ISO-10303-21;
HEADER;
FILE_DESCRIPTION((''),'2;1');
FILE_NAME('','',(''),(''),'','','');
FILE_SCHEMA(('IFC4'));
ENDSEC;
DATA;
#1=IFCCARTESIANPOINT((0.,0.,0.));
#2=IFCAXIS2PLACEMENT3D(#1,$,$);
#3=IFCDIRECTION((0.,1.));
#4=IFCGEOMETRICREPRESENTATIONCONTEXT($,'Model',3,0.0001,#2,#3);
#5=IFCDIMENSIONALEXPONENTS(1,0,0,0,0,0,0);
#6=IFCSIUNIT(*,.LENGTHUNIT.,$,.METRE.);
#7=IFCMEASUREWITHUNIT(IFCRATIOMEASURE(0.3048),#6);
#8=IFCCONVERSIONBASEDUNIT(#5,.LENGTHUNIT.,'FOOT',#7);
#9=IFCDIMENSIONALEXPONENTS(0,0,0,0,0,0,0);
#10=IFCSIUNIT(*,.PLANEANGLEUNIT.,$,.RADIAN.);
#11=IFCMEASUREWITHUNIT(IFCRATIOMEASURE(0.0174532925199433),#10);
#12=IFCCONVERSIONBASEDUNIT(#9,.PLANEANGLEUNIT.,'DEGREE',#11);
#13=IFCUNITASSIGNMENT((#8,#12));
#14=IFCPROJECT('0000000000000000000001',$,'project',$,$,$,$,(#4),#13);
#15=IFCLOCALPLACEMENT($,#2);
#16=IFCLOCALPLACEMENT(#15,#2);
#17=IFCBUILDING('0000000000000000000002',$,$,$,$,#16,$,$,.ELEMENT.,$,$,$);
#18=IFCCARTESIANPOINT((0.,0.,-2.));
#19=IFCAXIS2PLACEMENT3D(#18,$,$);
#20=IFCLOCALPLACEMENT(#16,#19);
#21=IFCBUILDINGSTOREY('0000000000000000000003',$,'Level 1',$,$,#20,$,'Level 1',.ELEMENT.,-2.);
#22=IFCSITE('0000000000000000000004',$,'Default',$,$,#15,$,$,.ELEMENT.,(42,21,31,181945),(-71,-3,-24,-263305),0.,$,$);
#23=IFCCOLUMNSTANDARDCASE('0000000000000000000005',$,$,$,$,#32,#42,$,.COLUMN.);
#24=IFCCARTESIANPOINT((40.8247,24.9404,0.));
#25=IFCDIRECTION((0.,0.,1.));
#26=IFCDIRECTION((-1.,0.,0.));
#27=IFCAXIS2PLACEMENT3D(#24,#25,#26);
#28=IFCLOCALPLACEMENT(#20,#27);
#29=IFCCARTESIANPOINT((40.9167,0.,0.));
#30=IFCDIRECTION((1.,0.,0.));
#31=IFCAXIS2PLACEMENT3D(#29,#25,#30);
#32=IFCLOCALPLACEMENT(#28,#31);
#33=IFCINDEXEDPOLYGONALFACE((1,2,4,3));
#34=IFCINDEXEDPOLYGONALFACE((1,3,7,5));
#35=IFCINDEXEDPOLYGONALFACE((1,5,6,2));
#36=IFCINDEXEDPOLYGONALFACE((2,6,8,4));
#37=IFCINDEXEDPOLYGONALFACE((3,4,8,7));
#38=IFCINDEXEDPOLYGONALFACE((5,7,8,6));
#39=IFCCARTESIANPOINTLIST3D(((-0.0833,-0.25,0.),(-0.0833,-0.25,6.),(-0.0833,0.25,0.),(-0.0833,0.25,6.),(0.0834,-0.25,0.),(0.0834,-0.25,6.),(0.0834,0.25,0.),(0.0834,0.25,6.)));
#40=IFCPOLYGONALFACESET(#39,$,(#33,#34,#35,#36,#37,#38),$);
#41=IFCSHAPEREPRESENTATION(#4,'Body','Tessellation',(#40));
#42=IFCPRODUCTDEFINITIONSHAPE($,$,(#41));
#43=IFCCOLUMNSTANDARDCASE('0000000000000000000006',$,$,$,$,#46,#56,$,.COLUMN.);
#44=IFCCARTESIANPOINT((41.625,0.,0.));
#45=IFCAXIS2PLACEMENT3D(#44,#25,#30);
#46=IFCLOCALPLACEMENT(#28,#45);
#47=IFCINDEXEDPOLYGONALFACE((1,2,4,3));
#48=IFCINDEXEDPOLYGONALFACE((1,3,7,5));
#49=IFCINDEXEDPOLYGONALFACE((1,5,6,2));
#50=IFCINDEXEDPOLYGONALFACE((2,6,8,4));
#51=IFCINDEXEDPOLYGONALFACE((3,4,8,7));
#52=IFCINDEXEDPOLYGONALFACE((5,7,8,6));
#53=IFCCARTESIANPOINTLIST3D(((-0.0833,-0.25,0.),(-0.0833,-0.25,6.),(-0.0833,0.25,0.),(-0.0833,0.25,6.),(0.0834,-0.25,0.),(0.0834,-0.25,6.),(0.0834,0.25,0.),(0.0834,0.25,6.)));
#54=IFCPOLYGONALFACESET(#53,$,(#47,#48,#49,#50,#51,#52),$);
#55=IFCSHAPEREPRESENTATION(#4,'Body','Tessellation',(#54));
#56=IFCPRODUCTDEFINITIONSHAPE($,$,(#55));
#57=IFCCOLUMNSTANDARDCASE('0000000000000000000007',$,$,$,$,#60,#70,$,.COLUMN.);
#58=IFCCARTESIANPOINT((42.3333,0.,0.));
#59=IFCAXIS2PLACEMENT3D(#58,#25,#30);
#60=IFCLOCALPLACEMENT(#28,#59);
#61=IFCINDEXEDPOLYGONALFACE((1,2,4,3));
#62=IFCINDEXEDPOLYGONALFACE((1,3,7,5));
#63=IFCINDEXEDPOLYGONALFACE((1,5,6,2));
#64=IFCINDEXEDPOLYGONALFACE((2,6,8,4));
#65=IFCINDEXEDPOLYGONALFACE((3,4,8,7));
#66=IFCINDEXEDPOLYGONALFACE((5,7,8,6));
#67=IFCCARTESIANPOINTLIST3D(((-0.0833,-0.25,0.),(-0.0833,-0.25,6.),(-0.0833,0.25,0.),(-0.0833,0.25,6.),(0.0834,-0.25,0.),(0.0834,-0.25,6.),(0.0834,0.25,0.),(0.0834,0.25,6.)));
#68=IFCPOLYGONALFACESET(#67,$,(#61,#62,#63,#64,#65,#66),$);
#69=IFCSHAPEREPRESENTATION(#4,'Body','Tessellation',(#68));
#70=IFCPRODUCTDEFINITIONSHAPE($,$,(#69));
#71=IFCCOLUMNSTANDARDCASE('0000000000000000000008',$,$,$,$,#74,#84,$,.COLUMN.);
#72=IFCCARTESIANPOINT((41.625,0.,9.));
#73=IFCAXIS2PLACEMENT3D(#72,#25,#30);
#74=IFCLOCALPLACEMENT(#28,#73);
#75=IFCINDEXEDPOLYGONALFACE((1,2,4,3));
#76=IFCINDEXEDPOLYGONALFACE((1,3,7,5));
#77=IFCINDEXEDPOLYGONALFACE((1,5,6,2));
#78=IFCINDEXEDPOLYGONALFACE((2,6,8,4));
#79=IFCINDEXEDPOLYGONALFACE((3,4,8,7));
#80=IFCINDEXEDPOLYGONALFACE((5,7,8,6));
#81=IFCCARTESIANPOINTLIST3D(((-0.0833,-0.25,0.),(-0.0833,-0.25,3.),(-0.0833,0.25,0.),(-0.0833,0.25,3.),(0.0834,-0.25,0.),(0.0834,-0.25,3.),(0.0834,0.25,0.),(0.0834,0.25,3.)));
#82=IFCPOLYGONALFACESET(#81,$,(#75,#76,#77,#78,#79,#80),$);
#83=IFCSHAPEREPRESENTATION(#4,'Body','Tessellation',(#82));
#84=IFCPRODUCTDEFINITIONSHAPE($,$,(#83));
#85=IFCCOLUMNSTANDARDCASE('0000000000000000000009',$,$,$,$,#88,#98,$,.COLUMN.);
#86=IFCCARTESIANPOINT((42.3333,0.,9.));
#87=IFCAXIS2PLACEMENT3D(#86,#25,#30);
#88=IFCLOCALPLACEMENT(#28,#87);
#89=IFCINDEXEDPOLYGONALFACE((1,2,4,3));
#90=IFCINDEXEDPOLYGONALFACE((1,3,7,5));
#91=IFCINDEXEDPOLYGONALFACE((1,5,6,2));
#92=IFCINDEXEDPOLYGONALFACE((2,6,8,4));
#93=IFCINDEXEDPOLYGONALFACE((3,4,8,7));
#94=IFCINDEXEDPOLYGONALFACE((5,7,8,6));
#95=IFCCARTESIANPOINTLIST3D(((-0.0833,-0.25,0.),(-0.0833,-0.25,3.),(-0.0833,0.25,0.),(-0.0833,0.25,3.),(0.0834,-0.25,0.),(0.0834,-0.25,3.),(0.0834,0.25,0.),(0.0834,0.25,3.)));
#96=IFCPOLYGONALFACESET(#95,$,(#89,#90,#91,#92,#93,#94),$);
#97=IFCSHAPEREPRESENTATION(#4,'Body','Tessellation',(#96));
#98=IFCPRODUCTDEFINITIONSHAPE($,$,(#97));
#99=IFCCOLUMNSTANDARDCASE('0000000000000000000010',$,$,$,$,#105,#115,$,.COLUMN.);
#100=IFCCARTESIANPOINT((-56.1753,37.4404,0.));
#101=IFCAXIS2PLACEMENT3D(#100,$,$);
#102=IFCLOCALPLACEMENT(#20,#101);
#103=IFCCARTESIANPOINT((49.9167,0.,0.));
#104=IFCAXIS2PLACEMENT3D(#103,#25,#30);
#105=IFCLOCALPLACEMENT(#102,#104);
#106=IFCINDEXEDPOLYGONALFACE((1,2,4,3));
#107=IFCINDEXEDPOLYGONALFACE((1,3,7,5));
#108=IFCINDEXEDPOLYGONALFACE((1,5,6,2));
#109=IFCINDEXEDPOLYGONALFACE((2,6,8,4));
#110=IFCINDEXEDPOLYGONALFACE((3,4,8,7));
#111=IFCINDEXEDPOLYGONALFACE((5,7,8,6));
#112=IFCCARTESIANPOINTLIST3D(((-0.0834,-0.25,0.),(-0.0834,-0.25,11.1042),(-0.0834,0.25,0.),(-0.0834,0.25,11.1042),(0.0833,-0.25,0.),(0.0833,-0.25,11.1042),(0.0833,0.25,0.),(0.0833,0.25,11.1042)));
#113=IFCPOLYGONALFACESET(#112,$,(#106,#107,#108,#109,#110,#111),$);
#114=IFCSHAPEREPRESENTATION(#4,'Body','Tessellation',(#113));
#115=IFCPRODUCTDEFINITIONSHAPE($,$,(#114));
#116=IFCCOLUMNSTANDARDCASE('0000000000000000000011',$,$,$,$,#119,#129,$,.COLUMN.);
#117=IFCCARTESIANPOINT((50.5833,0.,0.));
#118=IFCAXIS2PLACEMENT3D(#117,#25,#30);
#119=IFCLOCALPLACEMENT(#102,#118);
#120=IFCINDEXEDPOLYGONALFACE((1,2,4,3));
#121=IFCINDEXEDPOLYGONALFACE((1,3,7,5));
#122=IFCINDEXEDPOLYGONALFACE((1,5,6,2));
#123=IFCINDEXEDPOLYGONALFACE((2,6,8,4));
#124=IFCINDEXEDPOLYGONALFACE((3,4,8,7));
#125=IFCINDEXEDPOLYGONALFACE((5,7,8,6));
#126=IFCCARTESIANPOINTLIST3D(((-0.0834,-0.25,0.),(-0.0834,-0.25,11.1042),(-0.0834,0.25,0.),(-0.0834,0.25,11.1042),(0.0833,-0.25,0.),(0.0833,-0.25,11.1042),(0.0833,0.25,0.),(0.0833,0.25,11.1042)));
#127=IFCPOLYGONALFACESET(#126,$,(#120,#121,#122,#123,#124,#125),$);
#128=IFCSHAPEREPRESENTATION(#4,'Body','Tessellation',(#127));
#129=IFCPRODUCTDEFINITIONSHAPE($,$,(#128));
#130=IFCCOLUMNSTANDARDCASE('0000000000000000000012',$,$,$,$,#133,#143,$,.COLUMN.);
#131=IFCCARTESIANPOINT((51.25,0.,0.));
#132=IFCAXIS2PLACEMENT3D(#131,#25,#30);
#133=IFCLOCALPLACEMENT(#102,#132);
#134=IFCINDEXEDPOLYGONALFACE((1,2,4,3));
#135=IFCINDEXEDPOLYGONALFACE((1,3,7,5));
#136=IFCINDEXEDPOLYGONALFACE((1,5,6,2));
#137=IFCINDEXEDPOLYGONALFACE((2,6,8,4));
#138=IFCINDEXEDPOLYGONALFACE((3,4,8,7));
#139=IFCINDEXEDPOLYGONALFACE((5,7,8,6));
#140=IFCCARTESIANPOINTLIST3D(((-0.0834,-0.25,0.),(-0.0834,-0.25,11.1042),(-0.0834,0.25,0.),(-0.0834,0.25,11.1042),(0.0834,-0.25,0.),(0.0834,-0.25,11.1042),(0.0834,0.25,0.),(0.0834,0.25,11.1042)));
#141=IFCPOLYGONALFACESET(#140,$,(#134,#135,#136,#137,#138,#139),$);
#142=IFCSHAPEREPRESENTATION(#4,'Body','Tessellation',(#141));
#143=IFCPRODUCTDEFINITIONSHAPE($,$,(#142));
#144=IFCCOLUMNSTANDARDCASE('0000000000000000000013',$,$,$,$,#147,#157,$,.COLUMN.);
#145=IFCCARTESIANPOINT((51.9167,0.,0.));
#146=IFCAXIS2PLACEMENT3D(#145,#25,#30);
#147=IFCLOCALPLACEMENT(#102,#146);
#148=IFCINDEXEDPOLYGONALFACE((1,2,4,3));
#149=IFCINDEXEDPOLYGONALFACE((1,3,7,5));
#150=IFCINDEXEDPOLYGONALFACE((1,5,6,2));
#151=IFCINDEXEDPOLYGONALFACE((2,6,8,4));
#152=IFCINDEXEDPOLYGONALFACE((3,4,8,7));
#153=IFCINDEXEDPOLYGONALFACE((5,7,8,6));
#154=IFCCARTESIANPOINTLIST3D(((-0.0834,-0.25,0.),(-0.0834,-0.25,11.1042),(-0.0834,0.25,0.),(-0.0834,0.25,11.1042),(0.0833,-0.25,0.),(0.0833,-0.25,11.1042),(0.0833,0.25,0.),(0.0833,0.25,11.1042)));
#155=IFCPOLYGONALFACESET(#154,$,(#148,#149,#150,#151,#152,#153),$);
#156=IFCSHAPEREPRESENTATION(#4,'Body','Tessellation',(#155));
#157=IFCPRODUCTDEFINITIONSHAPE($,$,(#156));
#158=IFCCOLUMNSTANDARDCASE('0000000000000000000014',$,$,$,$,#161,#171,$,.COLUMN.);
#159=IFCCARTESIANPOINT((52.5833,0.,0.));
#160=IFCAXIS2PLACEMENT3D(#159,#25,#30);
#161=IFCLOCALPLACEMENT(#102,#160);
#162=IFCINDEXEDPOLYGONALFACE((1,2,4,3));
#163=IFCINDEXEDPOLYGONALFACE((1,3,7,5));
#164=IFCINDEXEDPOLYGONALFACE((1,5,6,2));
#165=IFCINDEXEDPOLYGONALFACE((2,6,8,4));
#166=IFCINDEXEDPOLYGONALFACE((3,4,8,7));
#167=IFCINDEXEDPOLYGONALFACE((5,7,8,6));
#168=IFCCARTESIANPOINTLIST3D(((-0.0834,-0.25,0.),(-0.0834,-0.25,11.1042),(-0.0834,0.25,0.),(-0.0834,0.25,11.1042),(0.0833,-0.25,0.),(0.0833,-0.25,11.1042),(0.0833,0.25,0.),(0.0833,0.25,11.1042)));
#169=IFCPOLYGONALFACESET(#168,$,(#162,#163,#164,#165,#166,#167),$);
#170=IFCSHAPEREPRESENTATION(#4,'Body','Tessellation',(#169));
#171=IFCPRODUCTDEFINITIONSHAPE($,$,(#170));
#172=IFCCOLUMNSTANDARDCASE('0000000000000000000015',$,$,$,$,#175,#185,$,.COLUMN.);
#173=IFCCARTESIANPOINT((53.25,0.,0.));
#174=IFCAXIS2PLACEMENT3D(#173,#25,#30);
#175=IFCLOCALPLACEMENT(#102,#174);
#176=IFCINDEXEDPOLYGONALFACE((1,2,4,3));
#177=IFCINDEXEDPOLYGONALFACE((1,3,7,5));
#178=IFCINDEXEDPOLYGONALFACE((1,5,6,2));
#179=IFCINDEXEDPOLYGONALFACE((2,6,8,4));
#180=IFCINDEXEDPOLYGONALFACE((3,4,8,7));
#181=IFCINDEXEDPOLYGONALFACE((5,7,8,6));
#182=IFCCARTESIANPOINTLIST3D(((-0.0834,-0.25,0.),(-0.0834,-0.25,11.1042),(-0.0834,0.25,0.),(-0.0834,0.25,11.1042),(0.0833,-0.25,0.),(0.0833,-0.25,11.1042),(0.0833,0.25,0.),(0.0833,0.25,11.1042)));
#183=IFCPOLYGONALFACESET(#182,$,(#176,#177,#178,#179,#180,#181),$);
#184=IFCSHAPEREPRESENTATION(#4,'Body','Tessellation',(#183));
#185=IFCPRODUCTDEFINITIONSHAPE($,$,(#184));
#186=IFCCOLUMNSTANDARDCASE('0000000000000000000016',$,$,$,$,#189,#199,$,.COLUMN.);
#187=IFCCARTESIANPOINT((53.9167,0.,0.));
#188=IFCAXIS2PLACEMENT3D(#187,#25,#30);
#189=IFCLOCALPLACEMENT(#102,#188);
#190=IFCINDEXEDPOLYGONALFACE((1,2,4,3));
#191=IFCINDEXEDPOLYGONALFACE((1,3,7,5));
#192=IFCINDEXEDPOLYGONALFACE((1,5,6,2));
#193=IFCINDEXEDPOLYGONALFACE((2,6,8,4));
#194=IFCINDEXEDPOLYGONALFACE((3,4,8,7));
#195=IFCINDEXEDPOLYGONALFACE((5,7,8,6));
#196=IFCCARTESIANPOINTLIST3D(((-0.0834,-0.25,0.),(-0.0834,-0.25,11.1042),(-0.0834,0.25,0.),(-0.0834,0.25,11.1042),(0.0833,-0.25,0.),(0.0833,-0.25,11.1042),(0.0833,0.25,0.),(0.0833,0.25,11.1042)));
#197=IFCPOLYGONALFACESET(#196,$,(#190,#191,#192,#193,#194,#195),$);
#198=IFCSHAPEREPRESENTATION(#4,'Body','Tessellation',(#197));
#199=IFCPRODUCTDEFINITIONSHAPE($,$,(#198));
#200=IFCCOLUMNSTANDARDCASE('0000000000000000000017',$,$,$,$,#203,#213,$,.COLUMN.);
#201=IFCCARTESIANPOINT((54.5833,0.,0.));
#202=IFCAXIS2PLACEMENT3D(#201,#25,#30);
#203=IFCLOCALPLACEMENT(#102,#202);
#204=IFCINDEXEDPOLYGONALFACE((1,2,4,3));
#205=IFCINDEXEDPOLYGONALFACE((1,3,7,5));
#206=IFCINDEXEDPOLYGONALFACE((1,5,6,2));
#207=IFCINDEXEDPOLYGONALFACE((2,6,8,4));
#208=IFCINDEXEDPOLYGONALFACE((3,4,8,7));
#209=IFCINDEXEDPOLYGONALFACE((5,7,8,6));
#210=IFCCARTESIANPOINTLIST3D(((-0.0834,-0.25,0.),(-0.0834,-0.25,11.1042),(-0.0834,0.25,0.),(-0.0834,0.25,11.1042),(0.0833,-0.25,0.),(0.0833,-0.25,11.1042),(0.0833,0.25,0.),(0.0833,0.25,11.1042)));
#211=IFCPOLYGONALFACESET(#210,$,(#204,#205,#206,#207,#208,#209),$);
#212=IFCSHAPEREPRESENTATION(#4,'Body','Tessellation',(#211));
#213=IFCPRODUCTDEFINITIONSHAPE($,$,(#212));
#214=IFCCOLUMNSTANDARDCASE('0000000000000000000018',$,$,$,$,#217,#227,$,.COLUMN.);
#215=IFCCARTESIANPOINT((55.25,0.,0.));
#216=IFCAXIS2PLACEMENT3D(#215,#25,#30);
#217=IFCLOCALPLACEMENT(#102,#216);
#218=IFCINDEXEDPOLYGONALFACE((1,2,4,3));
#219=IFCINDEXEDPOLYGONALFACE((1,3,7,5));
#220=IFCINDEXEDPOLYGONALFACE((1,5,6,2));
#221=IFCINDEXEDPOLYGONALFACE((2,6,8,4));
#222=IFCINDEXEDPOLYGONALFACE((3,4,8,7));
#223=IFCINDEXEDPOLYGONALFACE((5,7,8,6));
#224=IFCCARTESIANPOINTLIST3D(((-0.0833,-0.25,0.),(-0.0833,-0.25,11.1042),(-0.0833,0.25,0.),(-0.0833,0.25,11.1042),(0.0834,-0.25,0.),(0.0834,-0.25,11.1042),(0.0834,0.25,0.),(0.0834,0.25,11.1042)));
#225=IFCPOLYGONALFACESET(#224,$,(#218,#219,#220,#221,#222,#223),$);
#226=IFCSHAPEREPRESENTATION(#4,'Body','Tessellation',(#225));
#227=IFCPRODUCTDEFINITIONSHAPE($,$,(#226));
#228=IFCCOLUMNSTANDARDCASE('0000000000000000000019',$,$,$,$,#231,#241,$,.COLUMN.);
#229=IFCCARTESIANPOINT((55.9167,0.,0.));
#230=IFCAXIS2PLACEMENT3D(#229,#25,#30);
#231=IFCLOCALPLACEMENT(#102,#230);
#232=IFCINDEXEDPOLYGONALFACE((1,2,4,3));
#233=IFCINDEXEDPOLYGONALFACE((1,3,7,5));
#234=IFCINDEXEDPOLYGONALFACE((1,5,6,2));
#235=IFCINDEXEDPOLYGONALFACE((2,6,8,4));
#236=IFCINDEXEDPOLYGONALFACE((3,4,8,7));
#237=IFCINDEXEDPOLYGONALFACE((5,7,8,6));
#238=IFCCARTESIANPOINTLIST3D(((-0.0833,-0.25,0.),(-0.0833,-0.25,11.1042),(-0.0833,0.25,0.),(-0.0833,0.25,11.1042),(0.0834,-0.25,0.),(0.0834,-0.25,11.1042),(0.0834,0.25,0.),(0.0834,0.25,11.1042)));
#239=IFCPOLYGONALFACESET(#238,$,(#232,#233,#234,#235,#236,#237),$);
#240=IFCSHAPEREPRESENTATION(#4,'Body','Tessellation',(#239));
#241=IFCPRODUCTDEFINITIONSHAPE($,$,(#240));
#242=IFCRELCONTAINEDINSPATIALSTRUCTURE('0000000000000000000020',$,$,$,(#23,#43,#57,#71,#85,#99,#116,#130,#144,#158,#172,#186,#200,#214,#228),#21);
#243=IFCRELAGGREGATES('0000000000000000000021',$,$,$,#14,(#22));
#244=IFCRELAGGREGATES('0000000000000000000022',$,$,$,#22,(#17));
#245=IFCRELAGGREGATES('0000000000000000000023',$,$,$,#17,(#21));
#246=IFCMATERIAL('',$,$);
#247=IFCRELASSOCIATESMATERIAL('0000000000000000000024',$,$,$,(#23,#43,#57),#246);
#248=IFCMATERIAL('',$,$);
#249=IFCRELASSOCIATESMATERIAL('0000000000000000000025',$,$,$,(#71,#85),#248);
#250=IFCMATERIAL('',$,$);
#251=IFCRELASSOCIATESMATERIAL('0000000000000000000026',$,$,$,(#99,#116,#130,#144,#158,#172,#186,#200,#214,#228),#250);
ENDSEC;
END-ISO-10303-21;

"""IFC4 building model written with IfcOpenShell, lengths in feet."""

from ifc_helpers import new_model, entity, si_unit, converted_unit, direction, frame, origin, place, context, project, spatial, rectangle, extrude, material, element, save


model = new_model("IFC4")

# Units and contexts
model_context = context("Model", 3, precision=0.0001, world=origin(), true_north=direction((0.0, 1.0)))
ifc_project = project(units=[converted_unit("LENGTHUNIT", "FOOT", entity("IfcRatioMeasure", 0.3048), si_unit("LENGTHUNIT", "METRE"), dimensions=[1, 0, 0, 0, 0, 0, 0]), converted_unit("PLANEANGLEUNIT", "DEGREE", entity("IfcRatioMeasure", 0.0174532925199433), si_unit("PLANEANGLEUNIT", "RADIAN"), dimensions=[0, 0, 0, 0, 0, 0, 0])], contexts=[model_context])

# Site, building, storey
site_placement = place(None, origin())
site = spatial("IfcSite", under=ifc_project, at=site_placement, Name="Default", CompositionType="ELEMENT", RefLatitude=(42, 21, 31, 181945), RefLongitude=(-71, -3, -24, -263305), RefElevation=0.0)
building_placement = place(site_placement, origin())
building = spatial("IfcBuilding", under=site, at=building_placement, CompositionType="ELEMENT")
storey_placement = place(building_placement, frame((0.0, 0.0, -2.0)))
storey = spatial("IfcBuildingStorey", under=building, at=storey_placement, Name="Level 1", LongName="Level 1", CompositionType="ELEMENT", Elevation=-2.0)

# Columns
ifc_material_1 = material(Name="")
placement_1 = place(storey_placement, frame((40.8247, 24.9404, 0.0), z_axis=(0.0, 0.0, 1.0), x_axis=(-1.0, 0.0, 0.0)))
for number, where, z_axis, x_axis in (
    (1, (40.9167, 0.0, 0.0), (0.0, 0.0, 1.0), (1.0, 0.0, 0.0)),
    (2, (41.625, 0.0, 0.0), (0.0, 0.0, 1.0), (1.0, 0.0, 0.0)),
    (3, (42.3333, 0.0, 0.0), (0.0, 0.0, 1.0), (1.0, 0.0, 0.0)),
):
    element("IfcColumnStandardCase", number, at=place(placement_1, frame(where, z_axis=z_axis, x_axis=x_axis)), inside=storey, material=ifc_material_1, PredefinedType="COLUMN", context=model_context, shape_type="SweptSolid", body=[
        extrude(rectangle(XDim=0.1667, YDim=0.5), origin(), (0.0, 0.0, 1.0), 6.0),
    ])
ifc_material_2 = material(Name="")
for number, where, z_axis, x_axis in (
    (4, (41.625, 0.0, 9.0), (0.0, 0.0, 1.0), (1.0, 0.0, 0.0)),
    (5, (42.3333, 0.0, 9.0), (0.0, 0.0, 1.0), (1.0, 0.0, 0.0)),
):
    element("IfcColumnStandardCase", number, at=place(placement_1, frame(where, z_axis=z_axis, x_axis=x_axis)), inside=storey, material=ifc_material_2, PredefinedType="COLUMN", context=model_context, shape_type="SweptSolid", body=[
        extrude(rectangle(XDim=0.1667, YDim=0.5), origin(), (0.0, 0.0, 1.0), 3.0),
    ])
ifc_material_3 = material(Name="")
placement_2 = place(storey_placement, frame((-56.1753, 37.4404, 0.0)))
for number, where, z_axis, x_axis in (
    (6, (49.9167, 0.0, 0.0), (0.0, 0.0, 1.0), (1.0, 0.0, 0.0)),
    (7, (50.5833, 0.0, 0.0), (0.0, 0.0, 1.0), (1.0, 0.0, 0.0)),
    (8, (51.25, 0.0, 0.0), (0.0, 0.0, 1.0), (1.0, 0.0, 0.0)),
    (9, (51.9167, 0.0, 0.0), (0.0, 0.0, 1.0), (1.0, 0.0, 0.0)),
    (10, (52.5833, 0.0, 0.0), (0.0, 0.0, 1.0), (1.0, 0.0, 0.0)),
    (11, (53.25, 0.0, 0.0), (0.0, 0.0, 1.0), (1.0, 0.0, 0.0)),
    (12, (53.9167, 0.0, 0.0), (0.0, 0.0, 1.0), (1.0, 0.0, 0.0)),
    (13, (54.5833, 0.0, 0.0), (0.0, 0.0, 1.0), (1.0, 0.0, 0.0)),
    (14, (55.25, 0.0, 0.0), (0.0, 0.0, 1.0), (1.0, 0.0, 0.0)),
    (15, (55.9167, 0.0, 0.0), (0.0, 0.0, 1.0), (1.0, 0.0, 0.0)),
):
    element("IfcColumnStandardCase", number, at=place(placement_2, frame(where, z_axis=z_axis, x_axis=x_axis)), inside=storey, material=ifc_material_3, PredefinedType="COLUMN", context=model_context, shape_type="SweptSolid", body=[
        extrude(rectangle(XDim=0.1667, YDim=0.5), origin(), (0.0, 0.0, 1.0), 11.1042),
    ])

save(model, "model.ifc")
